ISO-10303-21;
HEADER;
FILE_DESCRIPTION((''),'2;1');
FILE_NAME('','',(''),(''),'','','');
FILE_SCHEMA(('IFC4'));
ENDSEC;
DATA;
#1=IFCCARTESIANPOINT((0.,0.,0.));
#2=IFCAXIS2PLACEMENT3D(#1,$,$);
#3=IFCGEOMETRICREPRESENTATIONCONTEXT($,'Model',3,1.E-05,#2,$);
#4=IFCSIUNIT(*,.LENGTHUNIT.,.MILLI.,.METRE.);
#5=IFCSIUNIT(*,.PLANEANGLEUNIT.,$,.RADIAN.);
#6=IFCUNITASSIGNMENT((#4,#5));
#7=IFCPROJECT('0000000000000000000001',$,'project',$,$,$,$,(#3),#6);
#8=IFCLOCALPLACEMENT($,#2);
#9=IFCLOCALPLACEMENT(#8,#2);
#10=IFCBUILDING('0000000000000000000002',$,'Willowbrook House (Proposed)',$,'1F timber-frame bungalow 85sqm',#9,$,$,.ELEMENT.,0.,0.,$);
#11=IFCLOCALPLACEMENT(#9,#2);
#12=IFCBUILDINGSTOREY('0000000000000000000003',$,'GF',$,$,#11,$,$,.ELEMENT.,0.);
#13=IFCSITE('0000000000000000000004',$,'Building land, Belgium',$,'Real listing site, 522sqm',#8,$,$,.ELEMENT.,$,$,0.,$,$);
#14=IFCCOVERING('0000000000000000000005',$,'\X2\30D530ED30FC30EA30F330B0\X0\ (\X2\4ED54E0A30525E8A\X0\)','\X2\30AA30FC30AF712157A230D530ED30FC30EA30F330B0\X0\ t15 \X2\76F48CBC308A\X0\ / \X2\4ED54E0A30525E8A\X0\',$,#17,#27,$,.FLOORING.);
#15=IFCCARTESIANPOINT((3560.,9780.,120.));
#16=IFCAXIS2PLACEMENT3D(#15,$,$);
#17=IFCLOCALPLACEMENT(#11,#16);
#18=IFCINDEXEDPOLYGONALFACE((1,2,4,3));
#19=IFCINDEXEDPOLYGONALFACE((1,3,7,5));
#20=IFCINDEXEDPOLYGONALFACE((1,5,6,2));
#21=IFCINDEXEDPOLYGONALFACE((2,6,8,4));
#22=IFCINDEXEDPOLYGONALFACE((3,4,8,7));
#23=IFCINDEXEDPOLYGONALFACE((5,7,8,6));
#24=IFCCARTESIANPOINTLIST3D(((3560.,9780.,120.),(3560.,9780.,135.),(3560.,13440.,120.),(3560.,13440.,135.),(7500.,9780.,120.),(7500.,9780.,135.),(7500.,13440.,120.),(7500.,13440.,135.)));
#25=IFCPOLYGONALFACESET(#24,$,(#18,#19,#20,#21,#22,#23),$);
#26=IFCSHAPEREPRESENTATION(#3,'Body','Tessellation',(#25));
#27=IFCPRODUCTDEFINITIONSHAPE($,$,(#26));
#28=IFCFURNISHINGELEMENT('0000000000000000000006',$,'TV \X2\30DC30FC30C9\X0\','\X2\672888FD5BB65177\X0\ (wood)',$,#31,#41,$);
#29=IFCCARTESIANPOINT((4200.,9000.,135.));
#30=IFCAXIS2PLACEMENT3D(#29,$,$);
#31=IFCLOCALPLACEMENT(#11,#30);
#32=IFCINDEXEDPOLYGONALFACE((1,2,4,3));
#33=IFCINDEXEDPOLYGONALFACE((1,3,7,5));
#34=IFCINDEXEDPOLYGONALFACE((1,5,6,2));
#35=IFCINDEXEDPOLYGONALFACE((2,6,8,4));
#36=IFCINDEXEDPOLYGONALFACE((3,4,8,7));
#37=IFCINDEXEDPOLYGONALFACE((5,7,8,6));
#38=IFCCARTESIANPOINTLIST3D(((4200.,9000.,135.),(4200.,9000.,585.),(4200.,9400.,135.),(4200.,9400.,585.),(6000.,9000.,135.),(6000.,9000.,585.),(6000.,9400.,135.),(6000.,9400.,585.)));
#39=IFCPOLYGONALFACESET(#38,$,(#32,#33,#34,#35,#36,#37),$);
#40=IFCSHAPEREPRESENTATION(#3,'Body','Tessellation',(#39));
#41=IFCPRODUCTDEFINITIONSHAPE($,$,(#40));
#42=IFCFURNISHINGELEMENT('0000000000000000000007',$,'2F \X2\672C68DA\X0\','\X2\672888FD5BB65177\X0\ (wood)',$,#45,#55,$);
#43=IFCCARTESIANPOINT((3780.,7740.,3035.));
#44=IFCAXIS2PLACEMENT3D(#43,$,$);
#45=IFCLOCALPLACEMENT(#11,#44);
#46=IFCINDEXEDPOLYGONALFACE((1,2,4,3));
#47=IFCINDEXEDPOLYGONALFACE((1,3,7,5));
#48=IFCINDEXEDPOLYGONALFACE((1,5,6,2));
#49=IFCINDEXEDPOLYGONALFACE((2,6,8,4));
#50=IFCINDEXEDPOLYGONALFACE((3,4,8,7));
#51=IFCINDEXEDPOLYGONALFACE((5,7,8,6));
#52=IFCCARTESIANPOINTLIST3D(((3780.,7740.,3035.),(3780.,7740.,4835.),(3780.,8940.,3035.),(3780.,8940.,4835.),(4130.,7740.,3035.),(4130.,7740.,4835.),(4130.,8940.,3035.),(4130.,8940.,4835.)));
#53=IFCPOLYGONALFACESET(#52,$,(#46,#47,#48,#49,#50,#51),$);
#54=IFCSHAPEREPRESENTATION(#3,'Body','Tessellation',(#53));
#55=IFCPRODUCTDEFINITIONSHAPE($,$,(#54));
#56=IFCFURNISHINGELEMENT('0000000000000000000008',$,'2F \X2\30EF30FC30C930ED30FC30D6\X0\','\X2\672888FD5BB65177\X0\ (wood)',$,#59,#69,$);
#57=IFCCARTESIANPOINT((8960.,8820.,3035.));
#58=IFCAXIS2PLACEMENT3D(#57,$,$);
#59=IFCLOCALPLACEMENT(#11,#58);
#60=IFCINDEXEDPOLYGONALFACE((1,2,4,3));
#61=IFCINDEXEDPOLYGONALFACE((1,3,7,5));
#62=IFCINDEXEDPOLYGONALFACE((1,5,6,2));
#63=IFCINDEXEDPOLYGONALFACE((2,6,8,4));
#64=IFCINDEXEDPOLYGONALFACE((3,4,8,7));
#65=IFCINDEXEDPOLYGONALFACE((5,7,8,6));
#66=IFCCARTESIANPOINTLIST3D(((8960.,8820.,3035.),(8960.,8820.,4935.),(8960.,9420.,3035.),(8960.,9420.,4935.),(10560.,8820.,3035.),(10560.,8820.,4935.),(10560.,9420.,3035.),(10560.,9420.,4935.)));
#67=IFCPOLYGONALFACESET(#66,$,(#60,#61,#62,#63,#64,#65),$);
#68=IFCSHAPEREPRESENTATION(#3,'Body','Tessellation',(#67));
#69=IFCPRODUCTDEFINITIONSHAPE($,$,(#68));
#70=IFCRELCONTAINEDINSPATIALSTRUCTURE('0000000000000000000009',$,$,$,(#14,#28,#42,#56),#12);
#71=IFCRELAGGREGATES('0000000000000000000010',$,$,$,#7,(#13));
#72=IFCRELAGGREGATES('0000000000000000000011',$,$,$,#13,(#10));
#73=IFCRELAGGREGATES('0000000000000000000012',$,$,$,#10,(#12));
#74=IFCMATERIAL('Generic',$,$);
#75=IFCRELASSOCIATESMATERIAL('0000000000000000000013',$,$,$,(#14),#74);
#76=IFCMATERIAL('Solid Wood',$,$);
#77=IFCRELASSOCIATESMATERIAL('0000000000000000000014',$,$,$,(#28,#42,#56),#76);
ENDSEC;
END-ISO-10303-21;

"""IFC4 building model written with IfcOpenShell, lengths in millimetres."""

from ifc_helpers import new_model, si_unit, frame, frame_2d, origin, place, context, project, spatial, rectangle, extrude, material, element, save


model = new_model("IFC4")

# Units and contexts
model_context = context("Model", 3, precision=1e-05, world=origin())
ifc_project = project(units=[si_unit("LENGTHUNIT", "METRE", prefix="MILLI"), si_unit("PLANEANGLEUNIT", "RADIAN")], contexts=[model_context])

# Site, building, storey
site_placement = place(None, origin())
site = spatial("IfcSite", under=ifc_project, at=site_placement, Name="Building land, Belgium", ObjectType="Real listing site, 522sqm", CompositionType="ELEMENT", RefElevation=0.0)
building_placement = place(site_placement, origin())
building = spatial("IfcBuilding", under=site, at=building_placement, Name="Willowbrook House (Proposed)", ObjectType="1F timber-frame bungalow 85sqm", CompositionType="ELEMENT", ElevationOfRefHeight=0.0, ElevationOfTerrain=0.0)
storey_placement = place(building_placement, origin())
storey = spatial("IfcBuildingStorey", under=building, at=storey_placement, Name="GF", CompositionType="ELEMENT", Elevation=0.0)

# Shared definitions
ifc_material_1 = material(Name="Solid Wood")

# Shared definitions
ifc_material_2 = material(Name="Generic")

# Covering
covering_placement = place(storey_placement, frame((3560.0, 9780.0, 120.0)))
element("IfcCovering", 1, at=covering_placement, inside=storey, material=ifc_material_2, Name="フローリング (仕上げ床)", Description="オーク無垢フローリング t15 直貼り / 仕上げ床", PredefinedType="FLOORING", context=model_context, shape_type="SweptSolid", body=[
    extrude(rectangle(XDim=3940.0, YDim=3660.0, at=frame_2d((1970.0, 1830.0))), frame((3560.0, 9780.0, 120.0)), (0.0, 0.0, 1.0), 15.0),
])

# Furnishing elements
furnishing_1_placement = place(storey_placement, frame((4200.0, 9000.0, 135.0)))
element("IfcFurnishingElement", 2, at=furnishing_1_placement, inside=storey, material=ifc_material_1, Name="TV ボード", Description="木製家具 (wood)", context=model_context, shape_type="SweptSolid", body=[
    extrude(rectangle(XDim=1800.0, YDim=400.0, at=frame_2d((900.0, 200.0))), frame((4200.0, 9000.0, 135.0)), (0.0, 0.0, 1.0), 450.0),
])
furnishing_2_placement = place(storey_placement, frame((3780.0, 7740.0, 3035.0)))
element("IfcFurnishingElement", 3, at=furnishing_2_placement, inside=storey, material=ifc_material_1, Name="2F 本棚", Description="木製家具 (wood)", context=model_context, shape_type="SweptSolid", body=[
    extrude(rectangle(XDim=350.0, YDim=1200.0, at=frame_2d((175.0, 600.0))), frame((3780.0, 7740.0, 3035.0)), (0.0, 0.0, 1.0), 1800.0),
])
furnishing_3_placement = place(storey_placement, frame((8960.0, 8820.0, 3035.0)))
element("IfcFurnishingElement", 4, at=furnishing_3_placement, inside=storey, material=ifc_material_1, Name="2F ワードローブ", Description="木製家具 (wood)", context=model_context, shape_type="SweptSolid", body=[
    extrude(rectangle(XDim=1600.0, YDim=600.0, at=frame_2d((800.0, 300.0))), frame((8960.0, 8820.0, 3035.0)), (0.0, 0.0, 1.0), 1900.0),
])

save(model, "model.ifc")
